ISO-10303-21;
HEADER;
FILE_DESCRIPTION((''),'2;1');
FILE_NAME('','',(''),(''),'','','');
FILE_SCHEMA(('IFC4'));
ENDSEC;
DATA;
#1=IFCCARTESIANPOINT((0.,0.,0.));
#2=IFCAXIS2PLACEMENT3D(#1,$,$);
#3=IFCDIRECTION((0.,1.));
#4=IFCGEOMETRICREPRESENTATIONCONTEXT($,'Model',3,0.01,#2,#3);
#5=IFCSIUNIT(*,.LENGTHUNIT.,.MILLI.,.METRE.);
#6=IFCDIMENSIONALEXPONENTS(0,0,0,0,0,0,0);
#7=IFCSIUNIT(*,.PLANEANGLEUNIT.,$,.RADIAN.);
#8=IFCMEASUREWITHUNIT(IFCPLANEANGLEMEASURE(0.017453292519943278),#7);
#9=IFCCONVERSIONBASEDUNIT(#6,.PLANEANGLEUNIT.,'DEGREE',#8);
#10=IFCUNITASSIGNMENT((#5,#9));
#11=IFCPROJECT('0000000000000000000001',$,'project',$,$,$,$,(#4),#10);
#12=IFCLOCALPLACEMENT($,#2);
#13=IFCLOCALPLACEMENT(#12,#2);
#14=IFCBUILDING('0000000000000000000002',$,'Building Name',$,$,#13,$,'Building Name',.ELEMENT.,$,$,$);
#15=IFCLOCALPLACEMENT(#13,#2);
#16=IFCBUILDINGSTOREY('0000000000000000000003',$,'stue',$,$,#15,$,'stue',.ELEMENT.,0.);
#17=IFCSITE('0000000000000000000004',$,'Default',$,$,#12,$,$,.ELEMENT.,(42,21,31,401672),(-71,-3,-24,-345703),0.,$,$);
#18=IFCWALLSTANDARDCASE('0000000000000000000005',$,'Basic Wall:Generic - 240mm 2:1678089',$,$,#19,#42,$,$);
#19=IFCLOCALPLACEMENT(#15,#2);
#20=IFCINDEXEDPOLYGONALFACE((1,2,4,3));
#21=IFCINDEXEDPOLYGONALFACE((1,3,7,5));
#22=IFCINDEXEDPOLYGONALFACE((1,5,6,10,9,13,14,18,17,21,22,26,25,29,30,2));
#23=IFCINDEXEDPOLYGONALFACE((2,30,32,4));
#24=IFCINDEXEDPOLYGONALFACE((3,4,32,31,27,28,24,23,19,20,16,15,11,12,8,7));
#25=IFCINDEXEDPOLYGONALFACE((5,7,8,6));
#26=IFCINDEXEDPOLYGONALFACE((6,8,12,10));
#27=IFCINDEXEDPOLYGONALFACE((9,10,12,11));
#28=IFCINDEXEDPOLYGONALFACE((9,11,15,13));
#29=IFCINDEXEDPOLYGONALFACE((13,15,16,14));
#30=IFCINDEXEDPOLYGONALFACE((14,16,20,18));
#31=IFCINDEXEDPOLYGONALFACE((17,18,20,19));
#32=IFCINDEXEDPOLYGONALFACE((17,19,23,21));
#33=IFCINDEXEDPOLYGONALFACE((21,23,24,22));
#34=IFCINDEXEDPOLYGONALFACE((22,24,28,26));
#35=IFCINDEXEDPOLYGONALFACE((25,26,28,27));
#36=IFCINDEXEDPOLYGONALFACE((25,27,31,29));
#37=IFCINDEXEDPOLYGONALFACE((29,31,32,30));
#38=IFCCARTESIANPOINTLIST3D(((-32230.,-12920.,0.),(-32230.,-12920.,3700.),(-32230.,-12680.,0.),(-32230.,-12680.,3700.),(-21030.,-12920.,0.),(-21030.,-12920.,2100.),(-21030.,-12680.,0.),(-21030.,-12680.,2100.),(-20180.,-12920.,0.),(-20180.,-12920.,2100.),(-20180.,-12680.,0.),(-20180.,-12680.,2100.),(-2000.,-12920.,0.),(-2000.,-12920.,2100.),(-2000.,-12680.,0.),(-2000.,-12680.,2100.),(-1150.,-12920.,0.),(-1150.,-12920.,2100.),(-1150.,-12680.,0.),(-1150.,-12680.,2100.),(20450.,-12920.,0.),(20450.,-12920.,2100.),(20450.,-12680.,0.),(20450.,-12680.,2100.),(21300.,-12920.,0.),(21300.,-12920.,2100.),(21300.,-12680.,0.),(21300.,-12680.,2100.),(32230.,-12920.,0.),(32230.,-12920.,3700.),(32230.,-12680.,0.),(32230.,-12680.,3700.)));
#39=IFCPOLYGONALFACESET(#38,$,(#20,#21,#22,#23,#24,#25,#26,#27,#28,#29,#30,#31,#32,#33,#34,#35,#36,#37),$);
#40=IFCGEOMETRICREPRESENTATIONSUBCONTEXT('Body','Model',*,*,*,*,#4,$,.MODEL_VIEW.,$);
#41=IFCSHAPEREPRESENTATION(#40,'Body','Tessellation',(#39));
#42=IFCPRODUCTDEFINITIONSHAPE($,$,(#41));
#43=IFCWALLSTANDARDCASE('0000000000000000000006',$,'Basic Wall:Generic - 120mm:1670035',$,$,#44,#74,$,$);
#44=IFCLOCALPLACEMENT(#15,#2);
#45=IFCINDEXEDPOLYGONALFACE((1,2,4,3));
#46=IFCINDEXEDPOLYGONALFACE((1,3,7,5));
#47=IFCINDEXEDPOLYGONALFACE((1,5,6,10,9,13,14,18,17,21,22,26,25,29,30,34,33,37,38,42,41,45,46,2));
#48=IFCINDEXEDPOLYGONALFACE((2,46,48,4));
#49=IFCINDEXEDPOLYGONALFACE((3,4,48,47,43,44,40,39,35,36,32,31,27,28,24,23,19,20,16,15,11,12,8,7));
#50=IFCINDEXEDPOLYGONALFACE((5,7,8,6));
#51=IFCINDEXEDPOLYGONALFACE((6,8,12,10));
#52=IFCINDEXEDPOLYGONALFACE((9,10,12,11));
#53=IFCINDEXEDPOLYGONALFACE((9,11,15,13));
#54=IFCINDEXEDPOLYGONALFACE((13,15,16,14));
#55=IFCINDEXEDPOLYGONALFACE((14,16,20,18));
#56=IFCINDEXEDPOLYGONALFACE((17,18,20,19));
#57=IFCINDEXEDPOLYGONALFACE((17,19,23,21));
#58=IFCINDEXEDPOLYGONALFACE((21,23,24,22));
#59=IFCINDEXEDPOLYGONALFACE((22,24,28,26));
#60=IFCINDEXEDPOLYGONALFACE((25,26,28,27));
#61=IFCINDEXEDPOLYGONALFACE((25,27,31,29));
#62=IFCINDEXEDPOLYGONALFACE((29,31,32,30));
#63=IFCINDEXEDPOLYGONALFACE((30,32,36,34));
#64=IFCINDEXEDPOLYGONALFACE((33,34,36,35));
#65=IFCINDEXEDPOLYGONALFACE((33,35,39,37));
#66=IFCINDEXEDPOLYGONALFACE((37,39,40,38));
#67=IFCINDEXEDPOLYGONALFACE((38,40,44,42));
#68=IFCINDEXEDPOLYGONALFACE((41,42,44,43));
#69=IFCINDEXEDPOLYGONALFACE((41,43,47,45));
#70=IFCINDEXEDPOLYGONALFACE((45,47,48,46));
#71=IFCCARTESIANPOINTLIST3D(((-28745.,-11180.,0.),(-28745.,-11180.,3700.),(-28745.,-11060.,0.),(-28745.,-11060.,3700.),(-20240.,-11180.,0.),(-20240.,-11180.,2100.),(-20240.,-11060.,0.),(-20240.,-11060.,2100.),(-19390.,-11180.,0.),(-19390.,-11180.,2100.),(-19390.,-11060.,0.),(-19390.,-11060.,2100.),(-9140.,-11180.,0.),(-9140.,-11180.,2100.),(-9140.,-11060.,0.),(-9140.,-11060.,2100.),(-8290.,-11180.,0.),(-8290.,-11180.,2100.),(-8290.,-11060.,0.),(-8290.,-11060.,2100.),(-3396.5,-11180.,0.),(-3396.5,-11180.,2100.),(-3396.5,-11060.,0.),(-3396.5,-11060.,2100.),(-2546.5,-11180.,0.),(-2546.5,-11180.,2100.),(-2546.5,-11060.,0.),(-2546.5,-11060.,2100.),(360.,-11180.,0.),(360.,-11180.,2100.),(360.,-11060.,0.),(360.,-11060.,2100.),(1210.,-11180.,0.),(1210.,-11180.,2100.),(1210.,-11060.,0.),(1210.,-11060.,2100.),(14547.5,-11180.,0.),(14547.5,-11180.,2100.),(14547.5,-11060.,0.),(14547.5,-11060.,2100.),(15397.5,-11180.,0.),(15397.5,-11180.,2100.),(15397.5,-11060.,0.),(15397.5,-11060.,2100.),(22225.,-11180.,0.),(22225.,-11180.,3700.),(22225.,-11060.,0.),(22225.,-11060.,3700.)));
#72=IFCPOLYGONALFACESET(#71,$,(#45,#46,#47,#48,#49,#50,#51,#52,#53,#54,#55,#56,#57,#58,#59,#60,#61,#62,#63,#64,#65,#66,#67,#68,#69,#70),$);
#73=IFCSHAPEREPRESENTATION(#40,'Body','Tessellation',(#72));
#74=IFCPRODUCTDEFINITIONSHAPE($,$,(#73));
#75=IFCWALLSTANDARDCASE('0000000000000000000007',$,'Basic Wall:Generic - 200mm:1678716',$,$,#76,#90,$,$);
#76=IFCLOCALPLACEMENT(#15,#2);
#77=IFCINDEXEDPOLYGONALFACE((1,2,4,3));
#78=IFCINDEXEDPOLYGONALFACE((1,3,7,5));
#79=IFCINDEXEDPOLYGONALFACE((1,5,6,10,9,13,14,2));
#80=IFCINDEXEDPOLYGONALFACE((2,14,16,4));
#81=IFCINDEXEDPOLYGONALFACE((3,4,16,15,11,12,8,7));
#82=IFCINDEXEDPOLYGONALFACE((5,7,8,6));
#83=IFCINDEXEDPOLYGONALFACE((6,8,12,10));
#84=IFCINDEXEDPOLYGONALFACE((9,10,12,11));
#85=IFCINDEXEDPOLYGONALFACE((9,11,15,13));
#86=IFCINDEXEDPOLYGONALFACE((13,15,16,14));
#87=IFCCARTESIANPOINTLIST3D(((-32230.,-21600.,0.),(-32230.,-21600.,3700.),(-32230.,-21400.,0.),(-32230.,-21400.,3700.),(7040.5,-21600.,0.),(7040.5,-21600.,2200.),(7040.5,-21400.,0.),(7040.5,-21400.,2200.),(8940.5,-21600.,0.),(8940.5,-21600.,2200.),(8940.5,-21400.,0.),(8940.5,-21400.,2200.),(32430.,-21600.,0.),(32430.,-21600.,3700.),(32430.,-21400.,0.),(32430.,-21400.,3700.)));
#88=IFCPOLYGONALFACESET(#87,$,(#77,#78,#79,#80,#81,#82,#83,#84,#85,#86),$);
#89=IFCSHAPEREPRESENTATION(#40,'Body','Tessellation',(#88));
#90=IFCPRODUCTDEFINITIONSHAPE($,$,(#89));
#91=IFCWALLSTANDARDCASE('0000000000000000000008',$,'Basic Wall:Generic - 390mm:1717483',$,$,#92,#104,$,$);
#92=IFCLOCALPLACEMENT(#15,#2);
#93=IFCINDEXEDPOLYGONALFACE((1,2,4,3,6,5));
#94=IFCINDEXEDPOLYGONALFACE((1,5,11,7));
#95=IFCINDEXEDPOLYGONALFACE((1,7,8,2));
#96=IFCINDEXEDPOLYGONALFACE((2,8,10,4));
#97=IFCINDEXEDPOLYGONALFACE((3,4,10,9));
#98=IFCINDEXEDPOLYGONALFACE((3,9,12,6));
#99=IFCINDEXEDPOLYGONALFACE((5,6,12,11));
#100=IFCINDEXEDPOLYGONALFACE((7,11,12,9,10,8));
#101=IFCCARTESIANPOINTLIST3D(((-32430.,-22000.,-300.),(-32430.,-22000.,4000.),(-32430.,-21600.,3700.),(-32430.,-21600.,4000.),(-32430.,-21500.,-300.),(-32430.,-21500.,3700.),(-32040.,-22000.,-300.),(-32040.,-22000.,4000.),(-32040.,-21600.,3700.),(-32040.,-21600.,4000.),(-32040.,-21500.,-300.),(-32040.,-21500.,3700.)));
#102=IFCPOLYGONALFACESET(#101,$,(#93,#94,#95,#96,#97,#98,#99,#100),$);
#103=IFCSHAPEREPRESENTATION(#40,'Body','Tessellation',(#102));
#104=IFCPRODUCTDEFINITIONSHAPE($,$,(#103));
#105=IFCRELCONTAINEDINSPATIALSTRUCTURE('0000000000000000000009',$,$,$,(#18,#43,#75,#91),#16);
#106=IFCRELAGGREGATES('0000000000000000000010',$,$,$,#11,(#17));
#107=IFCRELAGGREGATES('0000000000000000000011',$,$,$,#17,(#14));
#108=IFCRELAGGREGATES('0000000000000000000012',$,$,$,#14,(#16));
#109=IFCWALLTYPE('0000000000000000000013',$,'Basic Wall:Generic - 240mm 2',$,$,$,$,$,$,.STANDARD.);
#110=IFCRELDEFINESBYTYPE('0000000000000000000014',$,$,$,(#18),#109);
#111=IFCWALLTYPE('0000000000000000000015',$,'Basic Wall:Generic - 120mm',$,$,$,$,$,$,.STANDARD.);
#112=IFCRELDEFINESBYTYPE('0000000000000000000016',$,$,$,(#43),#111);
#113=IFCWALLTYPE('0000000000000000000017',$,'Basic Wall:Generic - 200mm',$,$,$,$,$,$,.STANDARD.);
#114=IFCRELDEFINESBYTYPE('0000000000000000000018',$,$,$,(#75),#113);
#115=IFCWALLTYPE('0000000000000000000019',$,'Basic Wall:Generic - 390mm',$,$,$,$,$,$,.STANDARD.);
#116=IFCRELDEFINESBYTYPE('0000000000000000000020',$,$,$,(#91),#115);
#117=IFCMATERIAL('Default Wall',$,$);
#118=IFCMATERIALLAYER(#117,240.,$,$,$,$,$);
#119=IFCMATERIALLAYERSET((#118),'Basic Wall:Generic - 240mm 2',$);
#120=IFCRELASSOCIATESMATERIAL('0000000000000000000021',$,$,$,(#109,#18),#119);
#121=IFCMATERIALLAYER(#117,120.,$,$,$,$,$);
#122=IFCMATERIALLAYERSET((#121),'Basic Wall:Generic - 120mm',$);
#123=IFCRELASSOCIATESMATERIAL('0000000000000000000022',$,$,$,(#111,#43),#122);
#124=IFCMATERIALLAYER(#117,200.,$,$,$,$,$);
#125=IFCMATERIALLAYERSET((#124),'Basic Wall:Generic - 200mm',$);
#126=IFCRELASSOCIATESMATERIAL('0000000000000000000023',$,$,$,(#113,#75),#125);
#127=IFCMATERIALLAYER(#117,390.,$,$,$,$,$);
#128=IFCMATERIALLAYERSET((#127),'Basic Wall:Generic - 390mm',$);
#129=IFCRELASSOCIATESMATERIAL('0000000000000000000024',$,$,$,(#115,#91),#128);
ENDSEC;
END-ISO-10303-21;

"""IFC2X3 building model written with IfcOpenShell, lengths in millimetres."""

from ifc_helpers import new_model, entity, si_unit, converted_unit, direction, frame, frame_2d, origin, place, context, subcontext, project, spatial, polyline, rectangle, extrude, clip, bounded_halfspace, material, layer, layer_set, layer_usage, type_object, element, save


model = new_model("IFC2X3")

# Units and contexts
model_context = context("Model", 3, precision=0.01, world=origin(), true_north=direction((0.0, 1.0)))
body_context = subcontext(model_context, "Body", "Model", "MODEL_VIEW")
ifc_project = project(units=[si_unit("LENGTHUNIT", "METRE", prefix="MILLI"), converted_unit("PLANEANGLEUNIT", "DEGREE", entity("IfcPlaneAngleMeasure", 0.017453292519943278), si_unit("PLANEANGLEUNIT", "RADIAN"), dimensions=[0, 0, 0, 0, 0, 0, 0])], contexts=[model_context])

# Site, building, storey
site_placement = place(None, origin())
site = spatial("IfcSite", under=ifc_project, at=site_placement, Name="Default", CompositionType="ELEMENT", RefLatitude=(42, 21, 31, 401672), RefLongitude=(-71, -3, -24, -345703), RefElevation=0.0)
building_placement = place(site_placement, origin())
building = spatial("IfcBuilding", under=site, at=building_placement, Name="Building Name", LongName="Building Name", CompositionType="ELEMENT")
storey_placement = place(building_placement, origin())
storey = spatial("IfcBuildingStorey", under=building, at=storey_placement, Name="stue", LongName="stue", CompositionType="ELEMENT", Elevation=0.0)

# Walls, openings
ifc_material_1 = material(Name="Default Wall")
ifc_layer_1 = layer(ifc_material_1, 240.0)
ifc_layer_set_1 = layer_set([ifc_layer_1], Name="Basic Wall:Generic - 240mm 2")
ifc_layer_usage_1 = layer_usage(ifc_layer_set_1, "AXIS2", "NEGATIVE", 120.0)
wall_type_1 = type_object("IfcWallType", Name="Basic Wall:Generic - 240mm 2", PredefinedType="STANDARD", material=ifc_layer_set_1)
wall_1_placement = place(storey_placement, frame((-32230.0, -12800.0, 0.0)))
wall_1 = element("IfcWallStandardCase", 1, at=wall_1_placement, inside=storey, type_object=wall_type_1, material=ifc_layer_usage_1, Name="Basic Wall:Generic - 240mm 2:1678089", context=body_context, shape_type="Clipping", body=[
    clip(clip(clip(extrude(rectangle(XDim=64460.0, YDim=240.0, at=frame_2d((32230.0, 0.0), x_axis=(-1.0, 0.0))), origin(), (0.0, 0.0, 1.0), 3700.0), bounded_halfspace(frame((64460.0, -120.0, 3700.0), z_axis=(0.0, 0.0, -1.0), x_axis=(-1.0, 0.0, 0.0)), True, frame((64460.0, -120.0, 3700.0)), polyline([(0.0, 0.0), (0.0, 240.0), (-9735.0, 240.0), (-9735.0, 0.0), (0.0, 0.0)]))), bounded_halfspace(frame((3355.0, -120.0, 3700.0), z_axis=(0.0, 0.0, -1.0), x_axis=(0.0, -1.0, 0.0)), True, frame((3355.0, -120.0, 3700.0)), polyline([(0.0, 0.0), (41525.0, 0.0), (41825.0, 0.0), (51370.0, 0.0), (51370.0, 240.0), (0.0, 240.0), (0.0, 0.0)]))), bounded_halfspace(frame((0.0, 120.0, 3700.0), z_axis=(0.0, 0.0, -1.0), x_axis=(-1.0, 0.0, 0.0)), True, frame((0.0, 120.0, 3700.0)), polyline([(0.0, 0.0), (0.0, -240.0), (3355.0, -240.0), (3355.0, 0.0), (0.0, 0.0)]))),
])
opening_1_placement = place(wall_1_placement, frame((12050.0, 120.0, 0.0)))
element("IfcOpeningElement", 2, at=opening_1_placement, cuts=wall_1, ObjectType="Opening", context=body_context, shape_type="SweptSolid", body=[
    extrude(rectangle(XDim=2100.0, YDim=850.0, at=frame_2d((1050.0, 425.0), x_axis=(1.0, 0.0))), frame((0.0, 0.0, 0.0), z_axis=(0.0, -1.0, 0.0), x_axis=(0.0, 0.0, 1.0)), (0.0, 0.0, 1.0), 240.0),
])
opening_2_placement = place(wall_1_placement, frame((31080.0, 120.0, 0.0)))
element("IfcOpeningElement", 3, at=opening_2_placement, cuts=wall_1, ObjectType="Opening", context=body_context, shape_type="SweptSolid", body=[
    extrude(rectangle(XDim=2100.0, YDim=850.0, at=frame_2d((1050.0, 425.0), x_axis=(1.0, 0.0))), frame((0.0, 0.0, 0.0), z_axis=(0.0, -1.0, 0.0), x_axis=(0.0, 0.0, 1.0)), (0.0, 0.0, 1.0), 240.0),
])
opening_3_placement = place(wall_1_placement, frame((53530.0, 120.0, 0.0)))
element("IfcOpeningElement", 4, at=opening_3_placement, cuts=wall_1, ObjectType="Opening", context=body_context, shape_type="SweptSolid", body=[
    extrude(rectangle(XDim=2100.0, YDim=850.0, at=frame_2d((1050.0, 425.0), x_axis=(1.0, 0.0))), frame((0.0, 0.0, 0.0), z_axis=(0.0, -1.0, 0.0), x_axis=(0.0, 0.0, 1.0)), (0.0, 0.0, 1.0), 240.0),
])
ifc_layer_2 = layer(ifc_material_1, 120.0)
ifc_layer_set_2 = layer_set([ifc_layer_2], Name="Basic Wall:Generic - 120mm")
ifc_layer_usage_2 = layer_usage(ifc_layer_set_2, "AXIS2", "NEGATIVE", 60.0)
wall_type_2 = type_object("IfcWallType", Name="Basic Wall:Generic - 120mm", PredefinedType="STANDARD", material=ifc_layer_set_2)
wall_2_placement = place(storey_placement, frame((-28745.0, -11120.0, 0.0)))
wall_2 = element("IfcWallStandardCase", 5, at=wall_2_placement, inside=storey, type_object=wall_type_2, material=ifc_layer_usage_2, Name="Basic Wall:Generic - 120mm:1670035", context=body_context, shape_type="Clipping", body=[
    clip(extrude(rectangle(XDim=50970.0, YDim=120.0, at=frame_2d((25485.0, 0.0), x_axis=(1.0, 0.0))), origin(), (0.0, 0.0, 1.0), 3700.0), bounded_halfspace(frame((0.0, -60.0, 3700.0), z_axis=(0.0, 0.0, -1.0), x_axis=(0.0, -1.0, 0.0)), True, frame((0.0, -60.0, 3700.0)), polyline([(0.0, 0.0), (70.0, 0.0), (50970.0, 0.0), (50970.0, 120.0), (48005.0, 120.0), (47885.0, 120.0), (44800.0, 120.0), (44690.0, 120.0), (42743.0, 120.0), (42633.0, 120.0), (38405.0, 120.0), (38285.0, 120.0), (35205.0, 120.0), (35085.0, 120.0), (30265.0, 120.0), (30155.0, 120.0), (26857.0, 120.0), (26747.0, 120.0), (24800.0, 120.0), (24690.0, 120.0), (19205.0, 120.0), (19085.0, 120.0), (16005.0, 120.0), (15885.0, 120.0), (11065.0, 120.0), (10955.0, 120.0), (120.0, 120.0), (70.0, 120.0), (0.0, 120.0), (0.0, 0.0)]))),
])
opening_4_placement = place(wall_2_placement, frame((43292.5, -60.0, 0.0)))
element("IfcOpeningElement", 6, at=opening_4_placement, cuts=wall_2, ObjectType="Opening", context=body_context, shape_type="SweptSolid", body=[
    extrude(rectangle(XDim=2100.0, YDim=850.0, at=frame_2d((1050.0, 425.0), x_axis=(1.0, 0.0))), frame((0.0, 0.0, 0.0), z_axis=(0.0, 1.0, 0.0), x_axis=(0.0, 0.0, 1.0)), (0.0, 0.0, 1.0), 120.0),
])
opening_5_placement = place(wall_2_placement, frame((25348.5, -60.0, 0.0)))
element("IfcOpeningElement", 7, at=opening_5_placement, cuts=wall_2, ObjectType="Opening", context=body_context, shape_type="SweptSolid", body=[
    extrude(rectangle(XDim=2100.0, YDim=850.0, at=frame_2d((1050.0, 425.0), x_axis=(1.0, 0.0))), frame((0.0, 0.0, 0.0), z_axis=(0.0, 1.0, 0.0), x_axis=(0.0, 0.0, 1.0)), (0.0, 0.0, 1.0), 120.0),
])
opening_6_placement = place(wall_2_placement, frame((8505.0, -60.0, 0.0)))
element("IfcOpeningElement", 8, at=opening_6_placement, cuts=wall_2, ObjectType="Opening", context=body_context, shape_type="SweptSolid", body=[
    extrude(rectangle(XDim=2100.0, YDim=850.0, at=frame_2d((1050.0, 425.0), x_axis=(1.0, 0.0))), frame((0.0, 0.0, 0.0), z_axis=(0.0, 1.0, 0.0), x_axis=(0.0, 0.0, 1.0)), (0.0, 0.0, 1.0), 120.0),
])
opening_7_placement = place(wall_2_placement, frame((19605.0, -60.0, 0.0)))
element("IfcOpeningElement", 9, at=opening_7_placement, cuts=wall_2, ObjectType="Opening", context=body_context, shape_type="SweptSolid", body=[
    extrude(rectangle(XDim=2100.0, YDim=850.0, at=frame_2d((1050.0, 425.0), x_axis=(1.0, 0.0))), frame((0.0, 0.0, 0.0), z_axis=(0.0, 1.0, 0.0), x_axis=(0.0, 0.0, 1.0)), (0.0, 0.0, 1.0), 120.0),
])
opening_8_placement = place(wall_2_placement, frame((29105.0, -60.0, 0.0)))
element("IfcOpeningElement", 10, at=opening_8_placement, cuts=wall_2, ObjectType="Opening", context=body_context, shape_type="SweptSolid", body=[
    extrude(rectangle(XDim=2100.0, YDim=850.0, at=frame_2d((1050.0, 425.0), x_axis=(1.0, 0.0))), frame((0.0, 0.0, 0.0), z_axis=(0.0, 1.0, 0.0), x_axis=(0.0, 0.0, 1.0)), (0.0, 0.0, 1.0), 120.0),
])

# Wall, opening
ifc_layer_3 = layer(ifc_material_1, 200.0)
ifc_layer_set_3 = layer_set([ifc_layer_3], Name="Basic Wall:Generic - 200mm")
ifc_layer_usage_3 = layer_usage(ifc_layer_set_3, "AXIS2", "NEGATIVE", 100.0)
wall_type_3 = type_object("IfcWallType", Name="Basic Wall:Generic - 200mm", PredefinedType="STANDARD", material=ifc_layer_set_3)
wall_3_placement = place(storey_placement, frame((-32230.0, -21500.0, 0.0)))
wall_3 = element("IfcWallStandardCase", 11, at=wall_3_placement, inside=storey, type_object=wall_type_3, material=ifc_layer_usage_3, Name="Basic Wall:Generic - 200mm:1678716", context=body_context, shape_type="Clipping", body=[
    clip(extrude(rectangle(XDim=64660.0, YDim=200.0, at=frame_2d((32330.0, 0.0), x_axis=(1.0, 0.0))), origin(), (0.0, 0.0, 1.0), 3700.0), bounded_halfspace(frame((0.0, -100.0, 3700.0), z_axis=(0.0, 0.0, -1.0), x_axis=(-1.0, 0.0, 0.0)), True, frame((0.0, -100.0, 3700.0)), polyline([(0.0, 0.0), (64660.0, 0.0), (64660.0, 200.0), (64460.0, 200.0), (45180.0, 200.0), (44880.0, 200.0), (0.0, 200.0), (0.0, 0.0)]))),
])
opening_9_placement = place(wall_3_placement, frame((39270.5, -100.0, 0.0)))
element("IfcOpeningElement", 12, at=opening_9_placement, cuts=wall_3, ObjectType="Opening", context=body_context, shape_type="SweptSolid", body=[
    extrude(rectangle(XDim=2200.0, YDim=1900.0, at=frame_2d((1100.0, 950.0), x_axis=(1.0, 0.0))), frame((0.0, 0.0, 0.0), z_axis=(0.0, 1.0, 0.0), x_axis=(0.0, 0.0, 1.0)), (0.0, 0.0, 1.0), 200.0),
])

# Wall
ifc_layer_4 = layer(ifc_material_1, 390.0)
ifc_layer_set_4 = layer_set([ifc_layer_4], Name="Basic Wall:Generic - 390mm")
ifc_layer_usage_4 = layer_usage(ifc_layer_set_4, "AXIS2", "NEGATIVE", 195.0)
wall_type_4 = type_object("IfcWallType", Name="Basic Wall:Generic - 390mm", PredefinedType="STANDARD", material=ifc_layer_set_4)
wall_4_placement = place(storey_placement, frame((-32235.0, -21500.0, -300.0), z_axis=(0.0, 0.0, 1.0), x_axis=(0.0, -1.0, 0.0)))
element("IfcWallStandardCase", 13, at=wall_4_placement, inside=storey, type_object=wall_type_4, material=ifc_layer_usage_4, Name="Basic Wall:Generic - 390mm:1717483", context=body_context, shape_type="Clipping", body=[
    clip(extrude(rectangle(XDim=500.0, YDim=390.0, at=frame_2d((250.0, 0.0), x_axis=(-1.0, 0.0))), origin(), (0.0, 0.0, 1.0), 4300.0), bounded_halfspace(frame((0.0, -195.0, 4000.0), z_axis=(0.0, 0.0, -1.0), x_axis=(0.0, -1.0, 0.0)), True, frame((0.0, -195.0, 4000.0)), polyline([(0.0, 0.0), (100.0, 0.0), (100.0, 390.0), (0.0, 390.0), (0.0, 0.0)]))),
])

save(model, "model.ifc")
